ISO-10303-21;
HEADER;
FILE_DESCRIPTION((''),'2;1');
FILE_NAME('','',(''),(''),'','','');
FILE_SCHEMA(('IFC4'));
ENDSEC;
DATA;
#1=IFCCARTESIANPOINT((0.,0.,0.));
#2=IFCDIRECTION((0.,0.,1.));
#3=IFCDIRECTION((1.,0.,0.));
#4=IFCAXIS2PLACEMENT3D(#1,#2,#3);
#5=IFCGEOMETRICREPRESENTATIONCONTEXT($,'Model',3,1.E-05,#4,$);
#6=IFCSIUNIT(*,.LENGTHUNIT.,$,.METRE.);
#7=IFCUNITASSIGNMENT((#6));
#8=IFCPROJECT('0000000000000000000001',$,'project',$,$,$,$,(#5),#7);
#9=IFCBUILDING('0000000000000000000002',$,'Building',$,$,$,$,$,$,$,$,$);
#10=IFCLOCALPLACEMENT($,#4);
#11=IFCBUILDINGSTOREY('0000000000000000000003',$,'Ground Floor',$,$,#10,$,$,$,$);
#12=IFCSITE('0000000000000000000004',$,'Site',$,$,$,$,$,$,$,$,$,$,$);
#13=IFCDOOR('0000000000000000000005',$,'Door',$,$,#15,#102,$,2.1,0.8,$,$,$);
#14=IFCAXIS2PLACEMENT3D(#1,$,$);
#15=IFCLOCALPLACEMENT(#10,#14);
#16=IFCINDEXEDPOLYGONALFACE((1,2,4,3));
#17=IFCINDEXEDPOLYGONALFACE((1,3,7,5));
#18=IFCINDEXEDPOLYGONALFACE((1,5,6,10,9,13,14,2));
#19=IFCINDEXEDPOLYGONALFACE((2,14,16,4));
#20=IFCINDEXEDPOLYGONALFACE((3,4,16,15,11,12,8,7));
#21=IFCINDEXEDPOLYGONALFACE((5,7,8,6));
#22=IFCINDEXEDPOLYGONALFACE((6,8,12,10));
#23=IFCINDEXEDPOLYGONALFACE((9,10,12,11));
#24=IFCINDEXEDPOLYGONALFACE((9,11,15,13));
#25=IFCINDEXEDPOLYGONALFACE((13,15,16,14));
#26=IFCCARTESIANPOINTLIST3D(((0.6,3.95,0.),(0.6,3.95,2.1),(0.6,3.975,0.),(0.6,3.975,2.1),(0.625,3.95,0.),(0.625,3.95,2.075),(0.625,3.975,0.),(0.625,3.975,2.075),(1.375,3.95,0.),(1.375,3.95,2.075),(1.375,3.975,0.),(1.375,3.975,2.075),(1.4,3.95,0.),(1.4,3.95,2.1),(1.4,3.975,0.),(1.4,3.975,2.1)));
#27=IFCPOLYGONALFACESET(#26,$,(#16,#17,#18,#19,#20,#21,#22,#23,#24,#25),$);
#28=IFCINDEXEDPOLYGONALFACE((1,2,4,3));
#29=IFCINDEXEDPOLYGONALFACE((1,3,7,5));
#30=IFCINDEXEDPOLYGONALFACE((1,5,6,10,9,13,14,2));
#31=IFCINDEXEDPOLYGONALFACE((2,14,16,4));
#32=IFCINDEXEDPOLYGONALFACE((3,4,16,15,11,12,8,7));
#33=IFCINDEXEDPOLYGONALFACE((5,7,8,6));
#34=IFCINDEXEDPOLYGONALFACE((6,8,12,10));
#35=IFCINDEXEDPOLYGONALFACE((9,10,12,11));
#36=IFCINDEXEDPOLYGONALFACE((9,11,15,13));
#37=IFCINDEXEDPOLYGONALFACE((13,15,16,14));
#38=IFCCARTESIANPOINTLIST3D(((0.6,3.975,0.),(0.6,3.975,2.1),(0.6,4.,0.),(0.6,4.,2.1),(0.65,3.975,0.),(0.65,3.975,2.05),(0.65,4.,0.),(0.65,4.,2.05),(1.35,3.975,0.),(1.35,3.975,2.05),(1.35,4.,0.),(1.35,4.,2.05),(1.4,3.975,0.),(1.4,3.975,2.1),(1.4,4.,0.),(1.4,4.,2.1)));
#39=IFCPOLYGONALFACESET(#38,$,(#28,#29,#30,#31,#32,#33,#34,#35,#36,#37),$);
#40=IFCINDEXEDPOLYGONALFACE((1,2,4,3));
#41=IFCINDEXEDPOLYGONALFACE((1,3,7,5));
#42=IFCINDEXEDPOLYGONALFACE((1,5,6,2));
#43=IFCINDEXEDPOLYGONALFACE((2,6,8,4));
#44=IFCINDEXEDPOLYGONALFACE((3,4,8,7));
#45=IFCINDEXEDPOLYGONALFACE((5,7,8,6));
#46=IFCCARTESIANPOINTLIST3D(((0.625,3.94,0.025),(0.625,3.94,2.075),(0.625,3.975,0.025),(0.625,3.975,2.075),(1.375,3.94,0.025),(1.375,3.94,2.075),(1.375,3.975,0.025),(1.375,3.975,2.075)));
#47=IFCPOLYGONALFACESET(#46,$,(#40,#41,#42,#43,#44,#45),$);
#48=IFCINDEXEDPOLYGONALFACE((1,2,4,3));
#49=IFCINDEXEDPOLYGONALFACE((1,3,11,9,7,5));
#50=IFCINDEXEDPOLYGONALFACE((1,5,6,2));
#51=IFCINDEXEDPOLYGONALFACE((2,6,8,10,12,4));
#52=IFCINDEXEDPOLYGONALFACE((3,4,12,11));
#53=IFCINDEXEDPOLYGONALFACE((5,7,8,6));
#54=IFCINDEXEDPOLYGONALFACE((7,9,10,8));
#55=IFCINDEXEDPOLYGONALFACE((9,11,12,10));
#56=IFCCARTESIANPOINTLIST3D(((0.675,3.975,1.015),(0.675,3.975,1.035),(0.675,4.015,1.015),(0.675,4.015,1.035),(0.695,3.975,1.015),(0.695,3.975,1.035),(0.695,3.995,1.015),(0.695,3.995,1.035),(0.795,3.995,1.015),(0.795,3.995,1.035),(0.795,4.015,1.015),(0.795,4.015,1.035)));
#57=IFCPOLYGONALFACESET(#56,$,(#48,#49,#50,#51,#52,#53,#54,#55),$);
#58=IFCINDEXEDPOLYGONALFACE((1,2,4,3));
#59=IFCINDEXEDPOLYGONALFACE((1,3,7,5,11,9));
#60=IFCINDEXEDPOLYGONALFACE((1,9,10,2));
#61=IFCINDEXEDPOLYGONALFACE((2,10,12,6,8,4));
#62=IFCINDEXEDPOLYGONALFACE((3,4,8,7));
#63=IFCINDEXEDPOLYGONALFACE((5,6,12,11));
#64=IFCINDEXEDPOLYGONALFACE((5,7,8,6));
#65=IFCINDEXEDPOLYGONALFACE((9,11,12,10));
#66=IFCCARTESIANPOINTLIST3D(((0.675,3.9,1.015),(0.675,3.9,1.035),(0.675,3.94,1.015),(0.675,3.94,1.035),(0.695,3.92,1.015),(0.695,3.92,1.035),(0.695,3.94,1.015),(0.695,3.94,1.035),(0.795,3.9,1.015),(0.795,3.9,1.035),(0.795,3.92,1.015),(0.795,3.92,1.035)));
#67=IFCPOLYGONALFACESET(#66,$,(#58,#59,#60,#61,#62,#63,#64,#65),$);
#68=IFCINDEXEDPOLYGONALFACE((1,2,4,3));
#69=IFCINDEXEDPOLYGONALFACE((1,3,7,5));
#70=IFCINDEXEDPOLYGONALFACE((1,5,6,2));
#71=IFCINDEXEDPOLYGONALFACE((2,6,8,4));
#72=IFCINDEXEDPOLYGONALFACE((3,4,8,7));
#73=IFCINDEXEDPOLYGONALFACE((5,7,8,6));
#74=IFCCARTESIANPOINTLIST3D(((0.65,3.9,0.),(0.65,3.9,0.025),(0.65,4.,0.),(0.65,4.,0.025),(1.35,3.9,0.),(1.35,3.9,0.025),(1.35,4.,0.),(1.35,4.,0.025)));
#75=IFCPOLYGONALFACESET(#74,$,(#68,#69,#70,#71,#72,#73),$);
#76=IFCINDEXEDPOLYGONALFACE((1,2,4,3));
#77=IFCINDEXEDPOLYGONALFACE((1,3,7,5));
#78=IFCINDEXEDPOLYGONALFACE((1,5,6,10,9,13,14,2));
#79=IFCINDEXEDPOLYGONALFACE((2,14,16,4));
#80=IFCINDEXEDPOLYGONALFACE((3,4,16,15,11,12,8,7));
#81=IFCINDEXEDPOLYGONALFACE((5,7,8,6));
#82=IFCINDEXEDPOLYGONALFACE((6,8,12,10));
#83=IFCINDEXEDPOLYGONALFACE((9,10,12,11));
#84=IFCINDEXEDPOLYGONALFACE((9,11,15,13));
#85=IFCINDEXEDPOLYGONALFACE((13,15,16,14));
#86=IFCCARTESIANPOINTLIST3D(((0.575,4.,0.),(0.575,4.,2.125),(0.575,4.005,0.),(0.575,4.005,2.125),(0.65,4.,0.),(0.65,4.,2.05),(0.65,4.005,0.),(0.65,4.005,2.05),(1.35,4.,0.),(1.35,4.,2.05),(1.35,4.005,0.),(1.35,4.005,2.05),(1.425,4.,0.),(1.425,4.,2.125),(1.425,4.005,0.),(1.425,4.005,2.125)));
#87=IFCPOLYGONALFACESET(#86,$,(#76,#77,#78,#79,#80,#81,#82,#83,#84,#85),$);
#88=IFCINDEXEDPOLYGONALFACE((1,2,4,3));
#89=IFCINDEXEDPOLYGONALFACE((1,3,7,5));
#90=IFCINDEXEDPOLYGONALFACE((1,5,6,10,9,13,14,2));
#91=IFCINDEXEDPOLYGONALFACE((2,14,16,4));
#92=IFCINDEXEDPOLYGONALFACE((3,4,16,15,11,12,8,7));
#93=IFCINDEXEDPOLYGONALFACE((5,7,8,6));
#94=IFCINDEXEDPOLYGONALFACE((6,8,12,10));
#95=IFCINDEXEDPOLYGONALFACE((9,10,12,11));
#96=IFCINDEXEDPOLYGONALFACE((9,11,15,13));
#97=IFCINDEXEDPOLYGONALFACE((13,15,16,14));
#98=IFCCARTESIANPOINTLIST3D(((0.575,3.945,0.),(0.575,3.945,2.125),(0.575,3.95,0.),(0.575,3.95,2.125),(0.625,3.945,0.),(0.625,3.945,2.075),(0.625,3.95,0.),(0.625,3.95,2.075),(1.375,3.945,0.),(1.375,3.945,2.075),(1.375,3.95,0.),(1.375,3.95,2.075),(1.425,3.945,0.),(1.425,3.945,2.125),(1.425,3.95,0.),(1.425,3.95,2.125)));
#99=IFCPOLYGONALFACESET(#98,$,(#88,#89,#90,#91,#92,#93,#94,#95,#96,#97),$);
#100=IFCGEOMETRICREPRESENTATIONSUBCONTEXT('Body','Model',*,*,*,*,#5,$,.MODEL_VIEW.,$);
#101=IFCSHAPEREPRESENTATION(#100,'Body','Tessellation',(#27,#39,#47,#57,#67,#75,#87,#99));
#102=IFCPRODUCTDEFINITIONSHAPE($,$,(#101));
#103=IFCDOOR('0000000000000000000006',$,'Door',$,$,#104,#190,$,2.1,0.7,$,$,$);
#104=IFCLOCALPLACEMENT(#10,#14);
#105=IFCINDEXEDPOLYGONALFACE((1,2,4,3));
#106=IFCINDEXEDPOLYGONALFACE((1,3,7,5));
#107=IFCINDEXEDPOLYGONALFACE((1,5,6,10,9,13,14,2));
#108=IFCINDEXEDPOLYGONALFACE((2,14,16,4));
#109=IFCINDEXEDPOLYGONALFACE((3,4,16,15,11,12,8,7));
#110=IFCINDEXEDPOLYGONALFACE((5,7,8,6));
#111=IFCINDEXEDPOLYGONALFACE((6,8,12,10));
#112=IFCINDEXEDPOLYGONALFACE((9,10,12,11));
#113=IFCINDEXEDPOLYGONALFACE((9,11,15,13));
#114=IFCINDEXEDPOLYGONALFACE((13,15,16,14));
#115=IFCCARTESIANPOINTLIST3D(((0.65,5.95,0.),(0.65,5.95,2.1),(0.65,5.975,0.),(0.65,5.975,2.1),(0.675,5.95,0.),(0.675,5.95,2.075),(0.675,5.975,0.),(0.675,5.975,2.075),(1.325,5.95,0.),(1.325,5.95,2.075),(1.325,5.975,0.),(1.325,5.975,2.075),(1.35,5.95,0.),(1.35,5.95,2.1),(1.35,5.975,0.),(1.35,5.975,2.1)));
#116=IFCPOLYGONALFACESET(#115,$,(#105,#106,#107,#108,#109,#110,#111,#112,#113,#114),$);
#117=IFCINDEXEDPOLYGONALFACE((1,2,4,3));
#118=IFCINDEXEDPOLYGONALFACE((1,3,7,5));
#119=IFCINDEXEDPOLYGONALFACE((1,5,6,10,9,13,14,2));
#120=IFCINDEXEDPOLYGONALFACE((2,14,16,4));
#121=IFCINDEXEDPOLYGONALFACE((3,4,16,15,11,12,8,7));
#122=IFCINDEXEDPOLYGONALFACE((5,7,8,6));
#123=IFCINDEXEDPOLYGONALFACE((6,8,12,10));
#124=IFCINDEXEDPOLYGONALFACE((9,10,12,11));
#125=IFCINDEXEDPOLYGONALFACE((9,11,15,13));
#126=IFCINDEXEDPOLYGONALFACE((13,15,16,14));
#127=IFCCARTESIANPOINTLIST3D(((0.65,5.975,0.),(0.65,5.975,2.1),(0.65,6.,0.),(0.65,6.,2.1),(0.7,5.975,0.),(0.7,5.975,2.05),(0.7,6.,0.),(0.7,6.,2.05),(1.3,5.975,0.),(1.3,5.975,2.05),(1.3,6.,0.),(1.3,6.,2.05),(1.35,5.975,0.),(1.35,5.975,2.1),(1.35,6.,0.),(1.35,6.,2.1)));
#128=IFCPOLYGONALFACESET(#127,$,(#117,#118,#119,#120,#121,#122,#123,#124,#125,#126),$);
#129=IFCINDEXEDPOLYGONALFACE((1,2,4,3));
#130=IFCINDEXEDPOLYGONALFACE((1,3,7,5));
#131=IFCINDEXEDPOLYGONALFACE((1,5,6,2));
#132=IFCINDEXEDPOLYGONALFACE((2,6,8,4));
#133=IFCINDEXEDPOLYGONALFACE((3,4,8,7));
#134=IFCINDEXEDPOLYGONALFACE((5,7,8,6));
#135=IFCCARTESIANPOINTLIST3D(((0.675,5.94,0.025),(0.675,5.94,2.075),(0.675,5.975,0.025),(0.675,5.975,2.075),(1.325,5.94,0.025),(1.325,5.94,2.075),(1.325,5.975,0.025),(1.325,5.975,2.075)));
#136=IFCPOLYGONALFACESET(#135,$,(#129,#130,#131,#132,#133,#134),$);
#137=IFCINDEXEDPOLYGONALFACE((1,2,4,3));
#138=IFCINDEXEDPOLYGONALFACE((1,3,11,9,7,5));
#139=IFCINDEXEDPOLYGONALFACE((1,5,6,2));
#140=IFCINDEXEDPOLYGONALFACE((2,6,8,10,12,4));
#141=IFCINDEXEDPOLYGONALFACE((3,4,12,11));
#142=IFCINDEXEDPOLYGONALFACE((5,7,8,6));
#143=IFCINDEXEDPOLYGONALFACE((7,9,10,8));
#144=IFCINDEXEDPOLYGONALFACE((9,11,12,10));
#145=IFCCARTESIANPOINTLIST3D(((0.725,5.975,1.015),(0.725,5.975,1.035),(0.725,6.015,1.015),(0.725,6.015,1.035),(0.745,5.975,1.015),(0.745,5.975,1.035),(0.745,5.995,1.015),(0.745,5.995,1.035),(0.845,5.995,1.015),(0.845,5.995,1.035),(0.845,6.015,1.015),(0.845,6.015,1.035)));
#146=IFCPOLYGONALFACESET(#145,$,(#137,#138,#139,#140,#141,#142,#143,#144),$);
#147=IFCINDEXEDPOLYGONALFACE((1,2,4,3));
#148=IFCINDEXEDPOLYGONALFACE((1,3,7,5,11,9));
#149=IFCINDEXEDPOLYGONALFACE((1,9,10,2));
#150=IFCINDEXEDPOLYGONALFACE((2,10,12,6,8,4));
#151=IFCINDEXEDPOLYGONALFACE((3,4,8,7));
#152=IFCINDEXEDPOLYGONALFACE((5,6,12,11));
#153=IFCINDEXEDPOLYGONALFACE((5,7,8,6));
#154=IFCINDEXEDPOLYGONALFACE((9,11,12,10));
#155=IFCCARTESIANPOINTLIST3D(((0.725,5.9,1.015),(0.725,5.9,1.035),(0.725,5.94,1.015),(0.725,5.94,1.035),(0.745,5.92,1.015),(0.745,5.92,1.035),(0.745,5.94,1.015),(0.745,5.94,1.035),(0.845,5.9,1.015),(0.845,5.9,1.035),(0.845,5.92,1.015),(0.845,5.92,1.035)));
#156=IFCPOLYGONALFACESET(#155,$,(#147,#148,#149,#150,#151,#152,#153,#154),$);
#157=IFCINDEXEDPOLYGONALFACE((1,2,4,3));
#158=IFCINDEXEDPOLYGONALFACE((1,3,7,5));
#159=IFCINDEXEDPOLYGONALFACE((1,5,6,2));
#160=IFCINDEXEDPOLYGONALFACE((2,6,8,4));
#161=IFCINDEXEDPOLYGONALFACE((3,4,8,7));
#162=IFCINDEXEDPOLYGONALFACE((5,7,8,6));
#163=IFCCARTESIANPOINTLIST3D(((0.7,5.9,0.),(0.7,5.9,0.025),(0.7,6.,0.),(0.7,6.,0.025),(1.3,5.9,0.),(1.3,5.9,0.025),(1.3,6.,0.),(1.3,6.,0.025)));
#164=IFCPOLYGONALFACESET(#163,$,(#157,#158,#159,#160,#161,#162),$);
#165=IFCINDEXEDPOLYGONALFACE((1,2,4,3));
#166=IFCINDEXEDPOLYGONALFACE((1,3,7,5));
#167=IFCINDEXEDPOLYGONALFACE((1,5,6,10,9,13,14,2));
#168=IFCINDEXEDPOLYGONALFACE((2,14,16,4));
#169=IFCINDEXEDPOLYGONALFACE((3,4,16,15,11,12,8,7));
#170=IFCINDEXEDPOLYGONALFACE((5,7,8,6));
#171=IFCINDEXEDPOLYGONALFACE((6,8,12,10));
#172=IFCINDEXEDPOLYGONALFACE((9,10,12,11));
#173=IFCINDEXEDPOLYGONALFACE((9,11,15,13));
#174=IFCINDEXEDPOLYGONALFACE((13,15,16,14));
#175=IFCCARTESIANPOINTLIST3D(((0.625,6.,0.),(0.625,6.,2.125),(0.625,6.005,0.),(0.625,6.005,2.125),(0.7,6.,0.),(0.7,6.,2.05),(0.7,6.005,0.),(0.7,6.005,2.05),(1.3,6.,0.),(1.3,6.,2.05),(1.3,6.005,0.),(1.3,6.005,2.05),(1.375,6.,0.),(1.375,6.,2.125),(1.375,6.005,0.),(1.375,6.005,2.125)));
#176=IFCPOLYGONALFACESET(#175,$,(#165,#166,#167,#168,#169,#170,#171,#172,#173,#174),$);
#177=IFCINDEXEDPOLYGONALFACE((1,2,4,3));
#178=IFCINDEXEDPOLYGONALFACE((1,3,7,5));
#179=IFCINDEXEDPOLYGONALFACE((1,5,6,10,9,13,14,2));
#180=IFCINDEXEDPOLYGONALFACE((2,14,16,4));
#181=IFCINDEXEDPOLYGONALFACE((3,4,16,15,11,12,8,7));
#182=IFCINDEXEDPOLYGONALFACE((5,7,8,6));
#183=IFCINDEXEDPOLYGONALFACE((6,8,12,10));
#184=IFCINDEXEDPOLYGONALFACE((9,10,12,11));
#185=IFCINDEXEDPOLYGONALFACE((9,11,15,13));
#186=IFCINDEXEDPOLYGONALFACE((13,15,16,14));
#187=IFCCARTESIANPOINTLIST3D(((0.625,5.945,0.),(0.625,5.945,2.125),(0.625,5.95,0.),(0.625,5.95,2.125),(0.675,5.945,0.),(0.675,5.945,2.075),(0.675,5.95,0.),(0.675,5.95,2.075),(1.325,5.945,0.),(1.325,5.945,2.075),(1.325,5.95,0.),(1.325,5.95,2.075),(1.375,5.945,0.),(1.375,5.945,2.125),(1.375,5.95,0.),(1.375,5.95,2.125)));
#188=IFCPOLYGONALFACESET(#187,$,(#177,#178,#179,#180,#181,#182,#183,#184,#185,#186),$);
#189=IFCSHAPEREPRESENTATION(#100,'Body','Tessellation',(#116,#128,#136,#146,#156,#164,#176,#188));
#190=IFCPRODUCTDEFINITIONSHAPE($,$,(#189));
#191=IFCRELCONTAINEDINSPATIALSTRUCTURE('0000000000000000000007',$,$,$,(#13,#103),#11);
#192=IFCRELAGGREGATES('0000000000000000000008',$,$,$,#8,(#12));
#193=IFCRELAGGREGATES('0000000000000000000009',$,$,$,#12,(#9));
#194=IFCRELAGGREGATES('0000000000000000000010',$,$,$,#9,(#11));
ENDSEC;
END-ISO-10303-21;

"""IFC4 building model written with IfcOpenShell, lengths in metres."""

from ifc_helpers import new_model, si_unit, frame, origin_with_axes, place, context, subcontext, project, spatial, line, indexed_curve, outline, extrude, element, save


model = new_model("IFC4")

# Units and contexts
model_context = context("Model", 3, precision=1e-05, world=origin_with_axes())
body_context = subcontext(model_context, "Body", "Model", "MODEL_VIEW")
ifc_project = project(units=[si_unit("LENGTHUNIT", "METRE")], contexts=[model_context])

# Site, building, storey
site = spatial("IfcSite", under=ifc_project, Name="Site")
building = spatial("IfcBuilding", under=site, Name="Building")
storey_placement = place(None, origin_with_axes())
storey = spatial("IfcBuildingStorey", under=building, at=storey_placement, Name="Ground Floor")

# Doors
door_1_placement = place(storey_placement, frame((1.4, 4.0, 0.0), z_axis=(0.0, 0.0, 1.0), x_axis=(-1.0, 0.0, 0.0)))
element("IfcDoor", 1, at=door_1_placement, inside=storey, Name="Door", OverallHeight=2.1, OverallWidth=0.8, context=body_context, shape_type="SweptSolid", body=[
    extrude(outline(indexed_curve([(0.0, 0.0), (0.0, 2.1), (0.8, 2.1), (0.8, 0.0), (0.775, 0.0), (0.775, 2.075), (0.025, 2.075), (0.025, 0.0)], segments=[line(1, 2, 3, 4, 5, 6, 7, 8, 1)])), frame((0.0, 0.025, 0.0), z_axis=(0.0, -1.0, 0.0), x_axis=(1.0, 0.0, 0.0)), (0.0, 0.0, -1.0), 0.025),
    extrude(outline(indexed_curve([(0.0, 0.0), (0.0, 2.1), (0.8, 2.1), (0.8, 0.0), (0.75, 0.0), (0.75, 2.05), (0.05, 2.05), (0.05, 0.0)], segments=[line(1, 2, 3, 4, 5, 6, 7, 8, 1)])), frame((0.0, 0.0, 0.0), z_axis=(0.0, -1.0, 0.0), x_axis=(1.0, 0.0, 0.0)), (0.0, 0.0, -1.0), 0.025),
    extrude(outline(indexed_curve([(0.0, 0.0), (0.75, 0.0), (0.75, 0.035), (0.0, 0.035)], segments=[line(1, 2, 3, 4, 1)])), frame((0.025, 0.025, 0.025), z_axis=(0.0, 0.0, 1.0), x_axis=(1.0, 0.0, 0.0)), (0.0, 0.0, 1.0), 2.05),
    extrude(outline(indexed_curve([(0.0, 0.0), (0.0, -0.04), (-0.12, -0.04), (-0.12, -0.02), (-0.02, -0.02), (-0.02, 0.0)], segments=[line(1, 2, 3, 4, 5, 6, 1)])), frame((0.725, 0.025, 1.015), z_axis=(0.0, 0.0, 1.0), x_axis=(1.0, 0.0, 0.0)), (0.0, 0.0, 1.0), 0.02),
    extrude(outline(indexed_curve([(0.0, 0.0), (0.0, 0.04), (-0.12, 0.04), (-0.12, 0.02), (-0.02, 0.02), (-0.02, 0.0)], segments=[line(1, 2, 3, 4, 5, 6, 1)])), frame((0.725, 0.06, 1.015), z_axis=(0.0, 0.0, 1.0), x_axis=(1.0, 0.0, 0.0)), (0.0, 0.0, 1.0), 0.02),
    extrude(outline(indexed_curve([(0.0, 0.0), (0.7, 0.0), (0.7, 0.1), (0.0, 0.1)], segments=[line(1, 2, 3, 4, 1)])), frame((0.05, 0.0, 0.0), z_axis=(0.0, 0.0, 1.0), x_axis=(1.0, 0.0, 0.0)), (0.0, 0.0, 1.0), 0.025),
    extrude(outline(indexed_curve([(0.0, 0.0), (0.0, 2.125), (0.85, 2.125), (0.85, 0.0), (0.775, 0.0), (0.775, 2.05), (0.075, 2.05), (0.075, 0.0)], segments=[line(1, 2, 3, 4, 5, 6, 7, 8, 1)])), frame((-0.025, -0.005, 0.0), z_axis=(0.0, -1.0, 0.0), x_axis=(1.0, 0.0, 0.0)), (0.0, 0.0, -1.0), 0.005),
    extrude(outline(indexed_curve([(0.0, 0.0), (0.0, 2.125), (0.85, 2.125), (0.85, 0.0), (0.8, 0.0), (0.8, 2.075), (0.05, 2.075), (0.05, 0.0)], segments=[line(1, 2, 3, 4, 5, 6, 7, 8, 1)])), frame((-0.025, 0.05, 0.0), z_axis=(0.0, -1.0, 0.0), x_axis=(1.0, 0.0, 0.0)), (0.0, 0.0, -1.0), 0.005),
])
door_2_placement = place(storey_placement, frame((1.35, 6.0, 0.0), z_axis=(0.0, 0.0, 1.0), x_axis=(-1.0, 0.0, 0.0)))
element("IfcDoor", 2, at=door_2_placement, inside=storey, Name="Door", OverallHeight=2.1, OverallWidth=0.7, context=body_context, shape_type="SweptSolid", body=[
    extrude(outline(indexed_curve([(0.0, 0.0), (0.0, 2.1), (0.7, 2.1), (0.7, 0.0), (0.675, 0.0), (0.675, 2.075), (0.025, 2.075), (0.025, 0.0)], segments=[line(1, 2, 3, 4, 5, 6, 7, 8, 1)])), frame((0.0, 0.025, 0.0), z_axis=(0.0, -1.0, 0.0), x_axis=(1.0, 0.0, 0.0)), (0.0, 0.0, -1.0), 0.025),
    extrude(outline(indexed_curve([(0.0, 0.0), (0.0, 2.1), (0.7, 2.1), (0.7, 0.0), (0.65, 0.0), (0.65, 2.05), (0.05, 2.05), (0.05, 0.0)], segments=[line(1, 2, 3, 4, 5, 6, 7, 8, 1)])), frame((0.0, 0.0, 0.0), z_axis=(0.0, -1.0, 0.0), x_axis=(1.0, 0.0, 0.0)), (0.0, 0.0, -1.0), 0.025),
    extrude(outline(indexed_curve([(0.0, 0.0), (0.65, 0.0), (0.65, 0.035), (0.0, 0.035)], segments=[line(1, 2, 3, 4, 1)])), frame((0.025, 0.025, 0.025), z_axis=(0.0, 0.0, 1.0), x_axis=(1.0, 0.0, 0.0)), (0.0, 0.0, 1.0), 2.05),
    extrude(outline(indexed_curve([(0.0, 0.0), (0.0, -0.04), (-0.12, -0.04), (-0.12, -0.02), (-0.02, -0.02), (-0.02, 0.0)], segments=[line(1, 2, 3, 4, 5, 6, 1)])), frame((0.625, 0.025, 1.015), z_axis=(0.0, 0.0, 1.0), x_axis=(1.0, 0.0, 0.0)), (0.0, 0.0, 1.0), 0.02),
    extrude(outline(indexed_curve([(0.0, 0.0), (0.0, 0.04), (-0.12, 0.04), (-0.12, 0.02), (-0.02, 0.02), (-0.02, 0.0)], segments=[line(1, 2, 3, 4, 5, 6, 1)])), frame((0.625, 0.06, 1.015), z_axis=(0.0, 0.0, 1.0), x_axis=(1.0, 0.0, 0.0)), (0.0, 0.0, 1.0), 0.02),
    extrude(outline(indexed_curve([(0.0, 0.0), (0.6, 0.0), (0.6, 0.1), (0.0, 0.1)], segments=[line(1, 2, 3, 4, 1)])), frame((0.05, 0.0, 0.0), z_axis=(0.0, 0.0, 1.0), x_axis=(1.0, 0.0, 0.0)), (0.0, 0.0, 1.0), 0.025),
    extrude(outline(indexed_curve([(0.0, 0.0), (0.0, 2.125), (0.75, 2.125), (0.75, 0.0), (0.675, 0.0), (0.675, 2.05), (0.075, 2.05), (0.075, 0.0)], segments=[line(1, 2, 3, 4, 5, 6, 7, 8, 1)])), frame((-0.025, -0.005, 0.0), z_axis=(0.0, -1.0, 0.0), x_axis=(1.0, 0.0, 0.0)), (0.0, 0.0, -1.0), 0.005),
    extrude(outline(indexed_curve([(0.0, 0.0), (0.0, 2.125), (0.75, 2.125), (0.75, 0.0), (0.7, 0.0), (0.7, 2.075), (0.05, 2.075), (0.05, 0.0)], segments=[line(1, 2, 3, 4, 5, 6, 7, 8, 1)])), frame((-0.025, 0.05, 0.0), z_axis=(0.0, -1.0, 0.0), x_axis=(1.0, 0.0, 0.0)), (0.0, 0.0, -1.0), 0.005),
])

save(model, "model.ifc")
